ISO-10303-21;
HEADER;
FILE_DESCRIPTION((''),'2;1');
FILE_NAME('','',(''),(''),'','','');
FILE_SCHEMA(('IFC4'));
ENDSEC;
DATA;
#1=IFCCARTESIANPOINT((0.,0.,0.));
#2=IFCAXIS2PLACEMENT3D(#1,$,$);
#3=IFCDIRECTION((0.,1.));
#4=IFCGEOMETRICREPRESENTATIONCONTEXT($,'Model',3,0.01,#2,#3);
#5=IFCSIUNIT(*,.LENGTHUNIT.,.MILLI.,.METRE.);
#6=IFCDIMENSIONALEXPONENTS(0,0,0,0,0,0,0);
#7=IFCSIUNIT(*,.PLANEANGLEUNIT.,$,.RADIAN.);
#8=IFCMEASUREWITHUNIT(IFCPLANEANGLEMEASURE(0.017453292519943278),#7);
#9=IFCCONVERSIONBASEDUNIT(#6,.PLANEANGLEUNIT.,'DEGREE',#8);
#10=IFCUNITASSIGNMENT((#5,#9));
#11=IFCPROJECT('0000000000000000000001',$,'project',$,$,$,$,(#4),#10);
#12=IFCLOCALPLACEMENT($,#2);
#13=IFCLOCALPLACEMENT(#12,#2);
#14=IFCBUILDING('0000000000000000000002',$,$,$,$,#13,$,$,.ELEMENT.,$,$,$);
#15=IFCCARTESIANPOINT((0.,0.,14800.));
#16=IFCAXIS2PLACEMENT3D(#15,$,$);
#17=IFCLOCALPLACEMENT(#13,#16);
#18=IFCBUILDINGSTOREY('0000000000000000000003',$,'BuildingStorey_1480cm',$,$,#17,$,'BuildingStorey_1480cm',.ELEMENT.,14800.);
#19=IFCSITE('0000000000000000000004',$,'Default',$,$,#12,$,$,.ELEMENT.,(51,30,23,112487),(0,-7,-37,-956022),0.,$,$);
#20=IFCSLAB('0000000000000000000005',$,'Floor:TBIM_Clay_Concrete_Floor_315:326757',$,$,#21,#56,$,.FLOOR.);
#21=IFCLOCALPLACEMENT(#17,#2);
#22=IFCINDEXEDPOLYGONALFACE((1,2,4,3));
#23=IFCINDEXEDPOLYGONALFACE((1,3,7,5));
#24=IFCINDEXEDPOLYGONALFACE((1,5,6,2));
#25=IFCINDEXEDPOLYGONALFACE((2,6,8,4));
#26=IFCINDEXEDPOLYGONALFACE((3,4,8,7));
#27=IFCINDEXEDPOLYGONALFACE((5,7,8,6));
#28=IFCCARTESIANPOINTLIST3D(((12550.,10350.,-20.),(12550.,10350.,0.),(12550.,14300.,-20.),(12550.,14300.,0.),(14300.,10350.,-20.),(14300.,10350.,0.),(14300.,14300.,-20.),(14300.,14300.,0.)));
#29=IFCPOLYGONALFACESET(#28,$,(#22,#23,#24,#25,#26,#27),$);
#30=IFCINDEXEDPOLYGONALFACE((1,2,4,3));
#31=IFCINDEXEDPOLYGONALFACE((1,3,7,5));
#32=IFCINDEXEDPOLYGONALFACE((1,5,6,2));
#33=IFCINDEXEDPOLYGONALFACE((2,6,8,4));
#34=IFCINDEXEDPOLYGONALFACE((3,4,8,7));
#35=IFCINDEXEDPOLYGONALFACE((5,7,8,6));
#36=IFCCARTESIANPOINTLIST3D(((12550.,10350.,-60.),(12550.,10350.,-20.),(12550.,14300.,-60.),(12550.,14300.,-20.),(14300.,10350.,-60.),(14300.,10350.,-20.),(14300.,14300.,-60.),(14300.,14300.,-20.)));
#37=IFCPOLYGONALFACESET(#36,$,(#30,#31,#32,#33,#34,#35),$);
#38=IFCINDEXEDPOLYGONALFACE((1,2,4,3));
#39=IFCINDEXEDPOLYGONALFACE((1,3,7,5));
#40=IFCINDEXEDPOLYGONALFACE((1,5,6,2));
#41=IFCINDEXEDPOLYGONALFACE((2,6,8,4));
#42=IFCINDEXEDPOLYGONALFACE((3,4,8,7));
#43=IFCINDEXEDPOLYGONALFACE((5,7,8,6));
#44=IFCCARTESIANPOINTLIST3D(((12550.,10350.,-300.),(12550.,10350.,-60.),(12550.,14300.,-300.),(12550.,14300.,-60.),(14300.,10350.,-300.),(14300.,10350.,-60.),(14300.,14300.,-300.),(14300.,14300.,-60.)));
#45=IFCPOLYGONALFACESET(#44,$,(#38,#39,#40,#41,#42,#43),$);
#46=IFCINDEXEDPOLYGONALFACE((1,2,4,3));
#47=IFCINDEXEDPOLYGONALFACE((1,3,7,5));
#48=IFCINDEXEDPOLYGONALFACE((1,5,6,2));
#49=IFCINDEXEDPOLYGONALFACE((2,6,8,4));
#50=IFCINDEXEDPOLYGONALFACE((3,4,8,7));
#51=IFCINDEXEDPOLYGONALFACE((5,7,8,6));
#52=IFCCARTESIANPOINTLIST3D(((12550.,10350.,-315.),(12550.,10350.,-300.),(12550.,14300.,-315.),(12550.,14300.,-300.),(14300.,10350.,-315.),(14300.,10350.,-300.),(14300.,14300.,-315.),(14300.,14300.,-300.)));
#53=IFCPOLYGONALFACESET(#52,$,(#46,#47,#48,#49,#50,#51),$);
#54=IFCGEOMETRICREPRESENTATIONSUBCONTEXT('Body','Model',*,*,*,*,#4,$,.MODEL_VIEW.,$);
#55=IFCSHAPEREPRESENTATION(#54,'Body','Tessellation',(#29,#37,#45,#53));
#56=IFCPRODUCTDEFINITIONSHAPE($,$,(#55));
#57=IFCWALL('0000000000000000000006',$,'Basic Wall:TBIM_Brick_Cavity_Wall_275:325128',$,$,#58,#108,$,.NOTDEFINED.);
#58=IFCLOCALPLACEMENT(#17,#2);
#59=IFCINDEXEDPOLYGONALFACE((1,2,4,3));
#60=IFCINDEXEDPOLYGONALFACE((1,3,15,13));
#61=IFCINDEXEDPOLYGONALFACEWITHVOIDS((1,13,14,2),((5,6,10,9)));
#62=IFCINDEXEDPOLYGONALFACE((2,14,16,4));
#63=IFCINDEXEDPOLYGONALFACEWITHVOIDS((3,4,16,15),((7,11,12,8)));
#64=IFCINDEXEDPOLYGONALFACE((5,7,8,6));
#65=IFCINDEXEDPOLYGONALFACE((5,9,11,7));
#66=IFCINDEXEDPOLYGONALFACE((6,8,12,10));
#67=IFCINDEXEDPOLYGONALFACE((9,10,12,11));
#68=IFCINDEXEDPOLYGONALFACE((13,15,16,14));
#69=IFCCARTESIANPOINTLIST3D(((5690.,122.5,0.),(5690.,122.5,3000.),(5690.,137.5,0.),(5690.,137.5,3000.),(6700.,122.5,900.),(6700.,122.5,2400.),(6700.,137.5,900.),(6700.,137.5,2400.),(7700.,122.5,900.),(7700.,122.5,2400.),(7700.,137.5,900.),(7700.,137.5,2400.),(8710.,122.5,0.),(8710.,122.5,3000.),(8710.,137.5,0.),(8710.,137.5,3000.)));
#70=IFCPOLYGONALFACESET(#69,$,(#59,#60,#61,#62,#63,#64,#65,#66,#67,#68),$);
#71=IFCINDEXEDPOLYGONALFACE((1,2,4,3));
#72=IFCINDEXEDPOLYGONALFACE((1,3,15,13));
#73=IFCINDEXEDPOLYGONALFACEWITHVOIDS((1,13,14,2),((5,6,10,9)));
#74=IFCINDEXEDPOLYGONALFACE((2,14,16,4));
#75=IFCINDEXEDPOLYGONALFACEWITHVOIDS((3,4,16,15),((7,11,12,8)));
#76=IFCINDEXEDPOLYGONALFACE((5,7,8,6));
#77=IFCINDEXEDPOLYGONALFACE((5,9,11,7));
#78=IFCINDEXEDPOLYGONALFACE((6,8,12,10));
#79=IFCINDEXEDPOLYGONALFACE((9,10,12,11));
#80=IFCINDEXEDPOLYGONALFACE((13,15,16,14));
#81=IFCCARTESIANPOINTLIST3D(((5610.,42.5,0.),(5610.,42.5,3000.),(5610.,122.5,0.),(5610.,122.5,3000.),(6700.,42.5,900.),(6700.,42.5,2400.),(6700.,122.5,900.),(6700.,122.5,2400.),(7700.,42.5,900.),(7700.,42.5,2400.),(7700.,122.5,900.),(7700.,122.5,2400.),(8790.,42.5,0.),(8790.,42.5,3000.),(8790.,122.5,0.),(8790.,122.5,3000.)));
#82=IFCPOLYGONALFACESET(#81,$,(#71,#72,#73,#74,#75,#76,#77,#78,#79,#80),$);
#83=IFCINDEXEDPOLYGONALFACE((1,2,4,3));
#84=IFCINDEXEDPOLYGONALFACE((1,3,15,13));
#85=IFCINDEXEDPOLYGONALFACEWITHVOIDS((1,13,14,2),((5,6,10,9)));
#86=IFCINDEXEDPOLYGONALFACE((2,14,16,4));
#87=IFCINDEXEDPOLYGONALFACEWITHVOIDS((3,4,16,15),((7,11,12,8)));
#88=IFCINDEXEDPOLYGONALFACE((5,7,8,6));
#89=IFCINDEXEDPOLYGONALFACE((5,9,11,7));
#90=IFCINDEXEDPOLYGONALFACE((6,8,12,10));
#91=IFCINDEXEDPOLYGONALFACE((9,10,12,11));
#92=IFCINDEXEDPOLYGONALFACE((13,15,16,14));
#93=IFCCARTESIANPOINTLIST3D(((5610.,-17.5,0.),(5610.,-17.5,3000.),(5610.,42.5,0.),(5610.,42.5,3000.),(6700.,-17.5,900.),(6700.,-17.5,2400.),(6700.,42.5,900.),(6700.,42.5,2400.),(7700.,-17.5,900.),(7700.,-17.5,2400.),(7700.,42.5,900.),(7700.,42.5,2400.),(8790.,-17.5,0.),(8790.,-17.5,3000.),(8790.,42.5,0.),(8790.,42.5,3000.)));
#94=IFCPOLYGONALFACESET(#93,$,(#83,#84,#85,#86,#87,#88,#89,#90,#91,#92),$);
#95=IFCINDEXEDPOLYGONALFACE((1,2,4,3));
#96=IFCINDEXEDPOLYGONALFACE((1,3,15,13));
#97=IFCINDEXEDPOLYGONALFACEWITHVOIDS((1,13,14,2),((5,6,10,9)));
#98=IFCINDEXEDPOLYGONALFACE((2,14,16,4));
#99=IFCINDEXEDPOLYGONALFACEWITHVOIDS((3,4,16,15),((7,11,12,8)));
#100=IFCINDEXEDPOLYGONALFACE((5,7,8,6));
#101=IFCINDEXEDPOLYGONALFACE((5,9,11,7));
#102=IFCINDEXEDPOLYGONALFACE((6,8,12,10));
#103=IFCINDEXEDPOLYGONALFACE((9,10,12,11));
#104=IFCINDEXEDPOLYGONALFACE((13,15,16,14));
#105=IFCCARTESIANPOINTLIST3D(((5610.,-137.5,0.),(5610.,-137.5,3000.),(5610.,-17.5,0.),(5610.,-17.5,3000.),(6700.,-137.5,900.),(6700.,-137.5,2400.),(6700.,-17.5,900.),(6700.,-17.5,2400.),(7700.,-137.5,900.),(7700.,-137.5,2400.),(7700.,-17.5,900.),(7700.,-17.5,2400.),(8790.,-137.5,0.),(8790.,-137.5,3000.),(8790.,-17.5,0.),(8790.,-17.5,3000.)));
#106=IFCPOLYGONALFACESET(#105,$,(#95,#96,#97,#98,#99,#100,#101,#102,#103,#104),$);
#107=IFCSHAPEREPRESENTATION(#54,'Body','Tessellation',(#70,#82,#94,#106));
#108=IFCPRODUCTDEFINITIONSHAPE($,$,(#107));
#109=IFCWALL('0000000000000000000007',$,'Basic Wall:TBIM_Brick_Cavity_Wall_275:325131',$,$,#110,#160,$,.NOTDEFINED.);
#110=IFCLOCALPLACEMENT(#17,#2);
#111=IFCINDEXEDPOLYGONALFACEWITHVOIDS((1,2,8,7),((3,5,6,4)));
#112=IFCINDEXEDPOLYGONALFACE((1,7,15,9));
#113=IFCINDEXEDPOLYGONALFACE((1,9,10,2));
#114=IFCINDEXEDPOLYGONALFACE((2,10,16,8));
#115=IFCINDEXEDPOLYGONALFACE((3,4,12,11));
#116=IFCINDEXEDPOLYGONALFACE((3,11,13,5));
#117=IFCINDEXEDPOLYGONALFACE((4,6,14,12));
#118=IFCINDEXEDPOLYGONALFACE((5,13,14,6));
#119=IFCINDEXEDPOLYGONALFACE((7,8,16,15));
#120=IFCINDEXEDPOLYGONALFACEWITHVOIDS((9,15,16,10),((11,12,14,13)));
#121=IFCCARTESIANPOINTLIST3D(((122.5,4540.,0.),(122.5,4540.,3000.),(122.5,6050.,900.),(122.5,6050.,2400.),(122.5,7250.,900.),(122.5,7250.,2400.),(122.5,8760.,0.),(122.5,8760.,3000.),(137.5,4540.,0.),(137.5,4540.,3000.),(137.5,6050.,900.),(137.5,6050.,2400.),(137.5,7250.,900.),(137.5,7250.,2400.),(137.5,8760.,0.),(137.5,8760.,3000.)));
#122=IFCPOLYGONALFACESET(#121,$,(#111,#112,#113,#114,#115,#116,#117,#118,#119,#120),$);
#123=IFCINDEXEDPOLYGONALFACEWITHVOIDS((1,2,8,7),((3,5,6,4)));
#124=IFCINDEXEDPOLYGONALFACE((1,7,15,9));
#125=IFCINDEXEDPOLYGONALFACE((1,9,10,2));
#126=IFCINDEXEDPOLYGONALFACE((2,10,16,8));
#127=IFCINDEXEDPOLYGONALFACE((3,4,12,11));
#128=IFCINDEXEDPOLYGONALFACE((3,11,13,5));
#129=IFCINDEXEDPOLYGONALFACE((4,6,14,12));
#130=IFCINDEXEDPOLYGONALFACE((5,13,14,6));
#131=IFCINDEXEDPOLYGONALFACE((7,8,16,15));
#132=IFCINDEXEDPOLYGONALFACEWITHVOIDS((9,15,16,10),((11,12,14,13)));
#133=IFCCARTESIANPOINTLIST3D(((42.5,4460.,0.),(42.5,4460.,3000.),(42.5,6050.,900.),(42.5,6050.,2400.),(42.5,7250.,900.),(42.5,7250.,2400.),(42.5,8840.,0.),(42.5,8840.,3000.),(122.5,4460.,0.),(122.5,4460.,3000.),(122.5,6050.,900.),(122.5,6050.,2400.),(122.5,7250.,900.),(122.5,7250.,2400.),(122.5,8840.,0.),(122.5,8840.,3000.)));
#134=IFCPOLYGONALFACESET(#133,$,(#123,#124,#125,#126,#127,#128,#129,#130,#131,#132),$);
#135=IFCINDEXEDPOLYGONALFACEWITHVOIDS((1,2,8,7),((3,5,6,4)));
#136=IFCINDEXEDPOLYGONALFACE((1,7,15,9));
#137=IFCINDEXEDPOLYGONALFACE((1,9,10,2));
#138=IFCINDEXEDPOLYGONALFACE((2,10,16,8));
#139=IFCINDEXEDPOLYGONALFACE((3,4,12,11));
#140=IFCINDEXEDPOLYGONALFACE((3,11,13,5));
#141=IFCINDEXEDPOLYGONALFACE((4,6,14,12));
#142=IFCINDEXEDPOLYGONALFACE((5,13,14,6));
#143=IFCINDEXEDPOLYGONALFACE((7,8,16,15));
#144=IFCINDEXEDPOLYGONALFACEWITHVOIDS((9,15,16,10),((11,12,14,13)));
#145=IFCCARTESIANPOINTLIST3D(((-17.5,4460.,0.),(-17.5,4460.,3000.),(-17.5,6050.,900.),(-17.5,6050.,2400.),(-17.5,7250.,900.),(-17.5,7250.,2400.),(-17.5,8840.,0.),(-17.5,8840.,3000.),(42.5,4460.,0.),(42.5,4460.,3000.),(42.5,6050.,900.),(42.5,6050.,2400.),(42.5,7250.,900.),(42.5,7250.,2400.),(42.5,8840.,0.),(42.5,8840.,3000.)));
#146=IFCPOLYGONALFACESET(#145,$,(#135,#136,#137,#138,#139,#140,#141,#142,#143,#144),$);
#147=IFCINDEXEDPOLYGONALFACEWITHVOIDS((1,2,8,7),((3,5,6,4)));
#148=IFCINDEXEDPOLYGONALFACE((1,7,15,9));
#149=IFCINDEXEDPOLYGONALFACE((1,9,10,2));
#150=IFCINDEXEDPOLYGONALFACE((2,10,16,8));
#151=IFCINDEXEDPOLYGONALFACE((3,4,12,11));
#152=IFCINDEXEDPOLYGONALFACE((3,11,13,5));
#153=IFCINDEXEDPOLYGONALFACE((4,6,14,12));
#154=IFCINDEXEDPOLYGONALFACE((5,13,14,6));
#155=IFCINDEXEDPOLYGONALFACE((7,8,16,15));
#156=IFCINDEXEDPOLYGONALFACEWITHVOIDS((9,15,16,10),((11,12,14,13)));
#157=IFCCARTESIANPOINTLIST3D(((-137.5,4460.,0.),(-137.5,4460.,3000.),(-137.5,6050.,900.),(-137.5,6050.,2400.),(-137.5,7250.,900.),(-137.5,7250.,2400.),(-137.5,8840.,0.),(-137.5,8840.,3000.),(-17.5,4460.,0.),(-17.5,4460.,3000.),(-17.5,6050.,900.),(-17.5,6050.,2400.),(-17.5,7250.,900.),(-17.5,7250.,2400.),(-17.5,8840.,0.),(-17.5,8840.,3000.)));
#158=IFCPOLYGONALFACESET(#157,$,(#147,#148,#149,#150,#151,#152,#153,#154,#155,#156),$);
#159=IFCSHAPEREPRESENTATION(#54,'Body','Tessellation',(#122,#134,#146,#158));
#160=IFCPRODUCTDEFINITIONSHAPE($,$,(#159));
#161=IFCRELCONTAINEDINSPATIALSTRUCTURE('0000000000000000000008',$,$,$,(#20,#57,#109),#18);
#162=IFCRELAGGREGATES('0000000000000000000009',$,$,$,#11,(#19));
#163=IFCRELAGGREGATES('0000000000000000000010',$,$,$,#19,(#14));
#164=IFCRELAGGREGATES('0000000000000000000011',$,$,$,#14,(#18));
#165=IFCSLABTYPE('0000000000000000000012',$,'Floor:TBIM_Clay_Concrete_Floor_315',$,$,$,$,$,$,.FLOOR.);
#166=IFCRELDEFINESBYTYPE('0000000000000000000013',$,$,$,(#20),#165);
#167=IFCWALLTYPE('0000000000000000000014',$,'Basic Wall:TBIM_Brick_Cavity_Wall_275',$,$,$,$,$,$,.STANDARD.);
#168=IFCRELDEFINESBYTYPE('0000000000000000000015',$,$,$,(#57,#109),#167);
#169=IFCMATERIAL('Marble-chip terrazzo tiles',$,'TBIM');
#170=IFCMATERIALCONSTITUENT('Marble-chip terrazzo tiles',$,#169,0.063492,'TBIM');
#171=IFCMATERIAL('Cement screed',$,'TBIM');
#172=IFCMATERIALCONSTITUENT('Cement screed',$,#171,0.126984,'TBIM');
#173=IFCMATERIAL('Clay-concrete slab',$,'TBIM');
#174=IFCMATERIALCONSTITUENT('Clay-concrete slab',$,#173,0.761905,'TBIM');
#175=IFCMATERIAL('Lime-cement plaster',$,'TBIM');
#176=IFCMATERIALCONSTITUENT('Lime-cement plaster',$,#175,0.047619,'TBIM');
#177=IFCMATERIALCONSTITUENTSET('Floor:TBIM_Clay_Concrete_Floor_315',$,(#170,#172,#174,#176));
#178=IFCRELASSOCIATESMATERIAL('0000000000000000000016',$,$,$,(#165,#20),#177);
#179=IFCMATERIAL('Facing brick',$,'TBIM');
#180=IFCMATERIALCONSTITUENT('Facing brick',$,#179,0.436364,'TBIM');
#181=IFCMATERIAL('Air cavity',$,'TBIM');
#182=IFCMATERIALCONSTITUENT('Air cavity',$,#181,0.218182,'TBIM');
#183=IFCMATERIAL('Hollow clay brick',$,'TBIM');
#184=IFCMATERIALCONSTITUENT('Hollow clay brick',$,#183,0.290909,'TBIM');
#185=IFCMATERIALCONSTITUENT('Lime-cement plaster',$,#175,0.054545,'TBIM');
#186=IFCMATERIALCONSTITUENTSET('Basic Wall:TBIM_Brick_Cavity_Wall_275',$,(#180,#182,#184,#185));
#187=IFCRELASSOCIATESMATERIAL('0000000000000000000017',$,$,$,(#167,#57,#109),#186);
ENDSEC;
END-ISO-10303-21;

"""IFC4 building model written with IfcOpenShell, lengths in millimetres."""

from ifc_helpers import new_model, entity, si_unit, converted_unit, direction, frame, origin, place, context, subcontext, project, spatial, indexed_curve, outline, extrude, material, constituent, constituent_set, type_object, element, save


model = new_model("IFC4")

# Units and contexts
model_context = context("Model", 3, precision=0.01, world=origin(), true_north=direction((0.0, 1.0)))
body_context = subcontext(model_context, "Body", "Model", "MODEL_VIEW")
ifc_project = project(units=[si_unit("LENGTHUNIT", "METRE", prefix="MILLI"), converted_unit("PLANEANGLEUNIT", "DEGREE", entity("IfcPlaneAngleMeasure", 0.017453292519943278), si_unit("PLANEANGLEUNIT", "RADIAN"), dimensions=[0, 0, 0, 0, 0, 0, 0])], contexts=[model_context])

# Site, building, storey
site_placement = place(None, origin())
site = spatial("IfcSite", under=ifc_project, at=site_placement, Name="Default", CompositionType="ELEMENT", RefLatitude=(51, 30, 23, 112487), RefLongitude=(0, -7, -37, -956022), RefElevation=0.0)
building_placement = place(site_placement, origin())
building = spatial("IfcBuilding", under=site, at=building_placement, CompositionType="ELEMENT")
storey_placement = place(building_placement, frame((0.0, 0.0, 14800.0)))
storey = spatial("IfcBuildingStorey", under=building, at=storey_placement, Name="BuildingStorey_1480cm", LongName="BuildingStorey_1480cm", CompositionType="ELEMENT", Elevation=14800.0)

# Slab
ifc_material_1 = material(Name="Marble-chip terrazzo tiles", Category="TBIM")
ifc_constituent_1 = constituent(ifc_material_1, Name="Marble-chip terrazzo tiles", Category="TBIM", fraction=0.063492)
ifc_material_2 = material(Name="Cement screed", Category="TBIM")
ifc_constituent_2 = constituent(ifc_material_2, Name="Cement screed", Category="TBIM", fraction=0.126984)
ifc_material_3 = material(Name="Clay-concrete slab", Category="TBIM")
ifc_constituent_3 = constituent(ifc_material_3, Name="Clay-concrete slab", Category="TBIM", fraction=0.761905)
ifc_material_4 = material(Name="Lime-cement plaster", Category="TBIM")
ifc_constituent_4 = constituent(ifc_material_4, Name="Lime-cement plaster", Category="TBIM", fraction=0.047619)
ifc_constituent_set_1 = constituent_set(constituents=[ifc_constituent_1, ifc_constituent_2, ifc_constituent_3, ifc_constituent_4], Name="Floor:TBIM_Clay_Concrete_Floor_315")
slab_type = type_object("IfcSlabType", Name="Floor:TBIM_Clay_Concrete_Floor_315", PredefinedType="FLOOR", material=ifc_constituent_set_1)
slab_1_placement = place(storey_placement, origin())
element("IfcSlab", 1, at=slab_1_placement, inside=storey, type_object=slab_type, material=ifc_constituent_set_1, Name="Floor:TBIM_Clay_Concrete_Floor_315:326757", PredefinedType="FLOOR", context=body_context, shape_type="SweptSolid", body=[
    extrude(outline(indexed_curve([(-875.0, -1975.0), (875.0, -1975.0), (875.0, 1975.0), (-875.0, 1975.0), (-875.0, -1975.0)], self_intersect=False)), frame((13425.0, 12325.0, -20.0), z_axis=(0.0, 0.0, 1.0), x_axis=(-1.0, 0.0, 0.0)), (0.0, 0.0, 1.0), 20.0),
    extrude(outline(indexed_curve([(-875.0, -1975.0), (875.0, -1975.0), (875.0, 1975.0), (-875.0, 1975.0), (-875.0, -1975.0)], self_intersect=False)), frame((13425.0, 12325.0, -60.0), z_axis=(0.0, 0.0, 1.0), x_axis=(-1.0, 0.0, 0.0)), (0.0, 0.0, 1.0), 40.0),
    extrude(outline(indexed_curve([(-875.0, -1975.0), (875.0, -1975.0), (875.0, 1975.0), (-875.0, 1975.0), (-875.0, -1975.0)], self_intersect=False)), frame((13425.0, 12325.0, -300.0), z_axis=(0.0, 0.0, 1.0), x_axis=(-1.0, 0.0, 0.0)), (0.0, 0.0, 1.0), 240.0),
    extrude(outline(indexed_curve([(-875.0, -1975.0), (875.0, -1975.0), (875.0, 1975.0), (-875.0, 1975.0), (-875.0, -1975.0)], self_intersect=False)), frame((13425.0, 12325.0, -315.0), z_axis=(0.0, 0.0, 1.0), x_axis=(-1.0, 0.0, 0.0)), (0.0, 0.0, 1.0), 15.0),
])

# Walls, openings
ifc_material_5 = material(Name="Facing brick", Category="TBIM")
ifc_constituent_5 = constituent(ifc_material_5, Name="Facing brick", Category="TBIM", fraction=0.436364)
ifc_material_6 = material(Name="Air cavity", Category="TBIM")
ifc_constituent_6 = constituent(ifc_material_6, Name="Air cavity", Category="TBIM", fraction=0.218182)
ifc_material_7 = material(Name="Hollow clay brick", Category="TBIM")
ifc_constituent_7 = constituent(ifc_material_7, Name="Hollow clay brick", Category="TBIM", fraction=0.290909)
ifc_constituent_8 = constituent(ifc_material_4, Name="Lime-cement plaster", Category="TBIM", fraction=0.054545)
ifc_constituent_set_2 = constituent_set(constituents=[ifc_constituent_5, ifc_constituent_6, ifc_constituent_7, ifc_constituent_8], Name="Basic Wall:TBIM_Brick_Cavity_Wall_275")
wall_type_1 = type_object("IfcWallType", Name="Basic Wall:TBIM_Brick_Cavity_Wall_275", PredefinedType="STANDARD", material=ifc_constituent_set_2)
wall_1_placement = place(storey_placement, frame((5595.0, 0.0, 0.0)))
wall_1 = element("IfcWall", 2, at=wall_1_placement, inside=storey, type_object=wall_type_1, material=ifc_constituent_set_2, Name="Basic Wall:TBIM_Brick_Cavity_Wall_275:325128", PredefinedType="NOTDEFINED", context=body_context, shape_type="SweptSolid", body=[
    extrude(outline(indexed_curve([(-1500.0, -1510.0), (1500.0, -1510.0), (1500.0, 1510.0), (-1500.0, 1510.0), (-1500.0, -1510.0)], self_intersect=False), holes=[indexed_curve([(-600.0, -500.0), (-600.0, 500.0), (900.0, 500.0), (900.0, -500.0), (-600.0, -500.0)], self_intersect=False)]), frame((1605.0, 122.5, 1500.0), z_axis=(0.0, 1.0, 0.0), x_axis=(0.0, 0.0, 1.0)), (0.0, 0.0, 1.0), 15.0),
    extrude(outline(indexed_curve([(-1500.0, -1590.0), (1500.0, -1590.0), (1500.0, 1590.0), (-1500.0, 1590.0), (-1500.0, -1590.0)], self_intersect=False), holes=[indexed_curve([(-600.0, -500.0), (-600.0, 500.0), (900.0, 500.0), (900.0, -500.0), (-600.0, -500.0)], self_intersect=False)]), frame((1605.0, 42.5, 1500.0), z_axis=(0.0, 1.0, 0.0), x_axis=(0.0, 0.0, 1.0)), (0.0, 0.0, 1.0), 80.0),
    extrude(outline(indexed_curve([(-1500.0, -1590.0), (1500.0, -1590.0), (1500.0, 1590.0), (-1500.0, 1590.0), (-1500.0, -1590.0)], self_intersect=False), holes=[indexed_curve([(-600.0, -500.0), (-600.0, 500.0), (900.0, 500.0), (900.0, -500.0), (-600.0, -500.0)], self_intersect=False)]), frame((1605.0, -17.5, 1500.0), z_axis=(0.0, 1.0, 0.0), x_axis=(0.0, 0.0, 1.0)), (0.0, 0.0, 1.0), 60.0),
    extrude(outline(indexed_curve([(-1500.0, -1590.0), (1500.0, -1590.0), (1500.0, 1590.0), (-1500.0, 1590.0), (-1500.0, -1590.0)], self_intersect=False), holes=[indexed_curve([(900.0, -500.0), (-600.0, -500.0), (-600.0, 500.0), (900.0, 500.0), (900.0, -500.0)], self_intersect=False)]), frame((1605.0, -137.5, 1500.0), z_axis=(0.0, 1.0, 0.0), x_axis=(0.0, 0.0, 1.0)), (0.0, 0.0, 1.0), 120.0),
])
opening_1_placement = place(wall_1_placement, frame((1105.0, -137.5, 900.0)))
element("IfcOpeningElement", 3, at=opening_1_placement, cuts=wall_1, PredefinedType="OPENING", context=body_context, shape_type="SweptSolid", body=[
    extrude(outline(indexed_curve([(1500.0, 0.0), (1500.0, 1000.0), (0.0, 1000.0), (0.0, 0.0), (1500.0, 0.0)], self_intersect=False)), frame((0.0, 0.0, 0.0), z_axis=(0.0, 1.0, 0.0), x_axis=(0.0, 0.0, 1.0)), (0.0, 0.0, 1.0), 275.0),
])
wall_2_placement = place(storey_placement, frame((0.0, 4445.0, 0.0), z_axis=(0.0, 0.0, 1.0), x_axis=(0.0, 1.0, 0.0)))
wall_2 = element("IfcWall", 4, at=wall_2_placement, inside=storey, type_object=wall_type_1, material=ifc_constituent_set_2, Name="Basic Wall:TBIM_Brick_Cavity_Wall_275:325131", PredefinedType="NOTDEFINED", context=body_context, shape_type="SweptSolid", body=[
    extrude(outline(indexed_curve([(-1500.0, -2110.0), (1500.0, -2110.0), (1500.0, 2110.0), (-1500.0, 2110.0), (-1500.0, -2110.0)], self_intersect=False), holes=[indexed_curve([(900.0, 600.0), (900.0, -600.0), (-600.0, -600.0), (-600.0, 600.0), (900.0, 600.0)], self_intersect=False)]), frame((2205.0, -122.5, 1500.0), z_axis=(0.0, -1.0, 0.0), x_axis=(0.0, 0.0, 1.0)), (0.0, 0.0, 1.0), 15.0),
    extrude(outline(indexed_curve([(-1500.0, -2190.0), (1500.0, -2190.0), (1500.0, 2190.0), (-1500.0, 2190.0), (-1500.0, -2190.0)], self_intersect=False), holes=[indexed_curve([(900.0, 600.0), (900.0, -600.0), (-600.0, -600.0), (-600.0, 600.0), (900.0, 600.0)], self_intersect=False)]), frame((2205.0, -42.5, 1500.0), z_axis=(0.0, -1.0, 0.0), x_axis=(0.0, 0.0, 1.0)), (0.0, 0.0, 1.0), 80.0),
    extrude(outline(indexed_curve([(-1500.0, -2190.0), (1500.0, -2190.0), (1500.0, 2190.0), (-1500.0, 2190.0), (-1500.0, -2190.0)], self_intersect=False), holes=[indexed_curve([(900.0, 600.0), (900.0, -600.0), (-600.0, -600.0), (-600.0, 600.0), (900.0, 600.0)], self_intersect=False)]), frame((2205.0, 17.5, 1500.0), z_axis=(0.0, -1.0, 0.0), x_axis=(0.0, 0.0, 1.0)), (0.0, 0.0, 1.0), 60.0),
    extrude(outline(indexed_curve([(-2190.0, -1500.0), (2190.0, -1500.0), (2190.0, 1500.0), (-2190.0, 1500.0), (-2190.0, -1500.0)], self_intersect=False), holes=[indexed_curve([(-600.0, 900.0), (600.0, 900.0), (600.0, -600.0), (-600.0, -600.0), (-600.0, 900.0)], self_intersect=False)]), frame((2205.0, 137.5, 1500.0), z_axis=(0.0, -1.0, 0.0), x_axis=(1.0, 0.0, 0.0)), (0.0, 0.0, 1.0), 120.0),
])
opening_2_placement = place(wall_2_placement, frame((1605.0, -137.5, 900.0)))
element("IfcOpeningElement", 5, at=opening_2_placement, cuts=wall_2, PredefinedType="OPENING", context=body_context, shape_type="SweptSolid", body=[
    extrude(outline(indexed_curve([(1500.0, 0.0), (1500.0, 1200.0), (0.0, 1200.0), (0.0, 0.0), (1500.0, 0.0)], self_intersect=False)), frame((0.0, 0.0, 0.0), z_axis=(0.0, 1.0, 0.0), x_axis=(0.0, 0.0, 1.0)), (0.0, 0.0, 1.0), 275.0),
])

save(model, "model.ifc")
